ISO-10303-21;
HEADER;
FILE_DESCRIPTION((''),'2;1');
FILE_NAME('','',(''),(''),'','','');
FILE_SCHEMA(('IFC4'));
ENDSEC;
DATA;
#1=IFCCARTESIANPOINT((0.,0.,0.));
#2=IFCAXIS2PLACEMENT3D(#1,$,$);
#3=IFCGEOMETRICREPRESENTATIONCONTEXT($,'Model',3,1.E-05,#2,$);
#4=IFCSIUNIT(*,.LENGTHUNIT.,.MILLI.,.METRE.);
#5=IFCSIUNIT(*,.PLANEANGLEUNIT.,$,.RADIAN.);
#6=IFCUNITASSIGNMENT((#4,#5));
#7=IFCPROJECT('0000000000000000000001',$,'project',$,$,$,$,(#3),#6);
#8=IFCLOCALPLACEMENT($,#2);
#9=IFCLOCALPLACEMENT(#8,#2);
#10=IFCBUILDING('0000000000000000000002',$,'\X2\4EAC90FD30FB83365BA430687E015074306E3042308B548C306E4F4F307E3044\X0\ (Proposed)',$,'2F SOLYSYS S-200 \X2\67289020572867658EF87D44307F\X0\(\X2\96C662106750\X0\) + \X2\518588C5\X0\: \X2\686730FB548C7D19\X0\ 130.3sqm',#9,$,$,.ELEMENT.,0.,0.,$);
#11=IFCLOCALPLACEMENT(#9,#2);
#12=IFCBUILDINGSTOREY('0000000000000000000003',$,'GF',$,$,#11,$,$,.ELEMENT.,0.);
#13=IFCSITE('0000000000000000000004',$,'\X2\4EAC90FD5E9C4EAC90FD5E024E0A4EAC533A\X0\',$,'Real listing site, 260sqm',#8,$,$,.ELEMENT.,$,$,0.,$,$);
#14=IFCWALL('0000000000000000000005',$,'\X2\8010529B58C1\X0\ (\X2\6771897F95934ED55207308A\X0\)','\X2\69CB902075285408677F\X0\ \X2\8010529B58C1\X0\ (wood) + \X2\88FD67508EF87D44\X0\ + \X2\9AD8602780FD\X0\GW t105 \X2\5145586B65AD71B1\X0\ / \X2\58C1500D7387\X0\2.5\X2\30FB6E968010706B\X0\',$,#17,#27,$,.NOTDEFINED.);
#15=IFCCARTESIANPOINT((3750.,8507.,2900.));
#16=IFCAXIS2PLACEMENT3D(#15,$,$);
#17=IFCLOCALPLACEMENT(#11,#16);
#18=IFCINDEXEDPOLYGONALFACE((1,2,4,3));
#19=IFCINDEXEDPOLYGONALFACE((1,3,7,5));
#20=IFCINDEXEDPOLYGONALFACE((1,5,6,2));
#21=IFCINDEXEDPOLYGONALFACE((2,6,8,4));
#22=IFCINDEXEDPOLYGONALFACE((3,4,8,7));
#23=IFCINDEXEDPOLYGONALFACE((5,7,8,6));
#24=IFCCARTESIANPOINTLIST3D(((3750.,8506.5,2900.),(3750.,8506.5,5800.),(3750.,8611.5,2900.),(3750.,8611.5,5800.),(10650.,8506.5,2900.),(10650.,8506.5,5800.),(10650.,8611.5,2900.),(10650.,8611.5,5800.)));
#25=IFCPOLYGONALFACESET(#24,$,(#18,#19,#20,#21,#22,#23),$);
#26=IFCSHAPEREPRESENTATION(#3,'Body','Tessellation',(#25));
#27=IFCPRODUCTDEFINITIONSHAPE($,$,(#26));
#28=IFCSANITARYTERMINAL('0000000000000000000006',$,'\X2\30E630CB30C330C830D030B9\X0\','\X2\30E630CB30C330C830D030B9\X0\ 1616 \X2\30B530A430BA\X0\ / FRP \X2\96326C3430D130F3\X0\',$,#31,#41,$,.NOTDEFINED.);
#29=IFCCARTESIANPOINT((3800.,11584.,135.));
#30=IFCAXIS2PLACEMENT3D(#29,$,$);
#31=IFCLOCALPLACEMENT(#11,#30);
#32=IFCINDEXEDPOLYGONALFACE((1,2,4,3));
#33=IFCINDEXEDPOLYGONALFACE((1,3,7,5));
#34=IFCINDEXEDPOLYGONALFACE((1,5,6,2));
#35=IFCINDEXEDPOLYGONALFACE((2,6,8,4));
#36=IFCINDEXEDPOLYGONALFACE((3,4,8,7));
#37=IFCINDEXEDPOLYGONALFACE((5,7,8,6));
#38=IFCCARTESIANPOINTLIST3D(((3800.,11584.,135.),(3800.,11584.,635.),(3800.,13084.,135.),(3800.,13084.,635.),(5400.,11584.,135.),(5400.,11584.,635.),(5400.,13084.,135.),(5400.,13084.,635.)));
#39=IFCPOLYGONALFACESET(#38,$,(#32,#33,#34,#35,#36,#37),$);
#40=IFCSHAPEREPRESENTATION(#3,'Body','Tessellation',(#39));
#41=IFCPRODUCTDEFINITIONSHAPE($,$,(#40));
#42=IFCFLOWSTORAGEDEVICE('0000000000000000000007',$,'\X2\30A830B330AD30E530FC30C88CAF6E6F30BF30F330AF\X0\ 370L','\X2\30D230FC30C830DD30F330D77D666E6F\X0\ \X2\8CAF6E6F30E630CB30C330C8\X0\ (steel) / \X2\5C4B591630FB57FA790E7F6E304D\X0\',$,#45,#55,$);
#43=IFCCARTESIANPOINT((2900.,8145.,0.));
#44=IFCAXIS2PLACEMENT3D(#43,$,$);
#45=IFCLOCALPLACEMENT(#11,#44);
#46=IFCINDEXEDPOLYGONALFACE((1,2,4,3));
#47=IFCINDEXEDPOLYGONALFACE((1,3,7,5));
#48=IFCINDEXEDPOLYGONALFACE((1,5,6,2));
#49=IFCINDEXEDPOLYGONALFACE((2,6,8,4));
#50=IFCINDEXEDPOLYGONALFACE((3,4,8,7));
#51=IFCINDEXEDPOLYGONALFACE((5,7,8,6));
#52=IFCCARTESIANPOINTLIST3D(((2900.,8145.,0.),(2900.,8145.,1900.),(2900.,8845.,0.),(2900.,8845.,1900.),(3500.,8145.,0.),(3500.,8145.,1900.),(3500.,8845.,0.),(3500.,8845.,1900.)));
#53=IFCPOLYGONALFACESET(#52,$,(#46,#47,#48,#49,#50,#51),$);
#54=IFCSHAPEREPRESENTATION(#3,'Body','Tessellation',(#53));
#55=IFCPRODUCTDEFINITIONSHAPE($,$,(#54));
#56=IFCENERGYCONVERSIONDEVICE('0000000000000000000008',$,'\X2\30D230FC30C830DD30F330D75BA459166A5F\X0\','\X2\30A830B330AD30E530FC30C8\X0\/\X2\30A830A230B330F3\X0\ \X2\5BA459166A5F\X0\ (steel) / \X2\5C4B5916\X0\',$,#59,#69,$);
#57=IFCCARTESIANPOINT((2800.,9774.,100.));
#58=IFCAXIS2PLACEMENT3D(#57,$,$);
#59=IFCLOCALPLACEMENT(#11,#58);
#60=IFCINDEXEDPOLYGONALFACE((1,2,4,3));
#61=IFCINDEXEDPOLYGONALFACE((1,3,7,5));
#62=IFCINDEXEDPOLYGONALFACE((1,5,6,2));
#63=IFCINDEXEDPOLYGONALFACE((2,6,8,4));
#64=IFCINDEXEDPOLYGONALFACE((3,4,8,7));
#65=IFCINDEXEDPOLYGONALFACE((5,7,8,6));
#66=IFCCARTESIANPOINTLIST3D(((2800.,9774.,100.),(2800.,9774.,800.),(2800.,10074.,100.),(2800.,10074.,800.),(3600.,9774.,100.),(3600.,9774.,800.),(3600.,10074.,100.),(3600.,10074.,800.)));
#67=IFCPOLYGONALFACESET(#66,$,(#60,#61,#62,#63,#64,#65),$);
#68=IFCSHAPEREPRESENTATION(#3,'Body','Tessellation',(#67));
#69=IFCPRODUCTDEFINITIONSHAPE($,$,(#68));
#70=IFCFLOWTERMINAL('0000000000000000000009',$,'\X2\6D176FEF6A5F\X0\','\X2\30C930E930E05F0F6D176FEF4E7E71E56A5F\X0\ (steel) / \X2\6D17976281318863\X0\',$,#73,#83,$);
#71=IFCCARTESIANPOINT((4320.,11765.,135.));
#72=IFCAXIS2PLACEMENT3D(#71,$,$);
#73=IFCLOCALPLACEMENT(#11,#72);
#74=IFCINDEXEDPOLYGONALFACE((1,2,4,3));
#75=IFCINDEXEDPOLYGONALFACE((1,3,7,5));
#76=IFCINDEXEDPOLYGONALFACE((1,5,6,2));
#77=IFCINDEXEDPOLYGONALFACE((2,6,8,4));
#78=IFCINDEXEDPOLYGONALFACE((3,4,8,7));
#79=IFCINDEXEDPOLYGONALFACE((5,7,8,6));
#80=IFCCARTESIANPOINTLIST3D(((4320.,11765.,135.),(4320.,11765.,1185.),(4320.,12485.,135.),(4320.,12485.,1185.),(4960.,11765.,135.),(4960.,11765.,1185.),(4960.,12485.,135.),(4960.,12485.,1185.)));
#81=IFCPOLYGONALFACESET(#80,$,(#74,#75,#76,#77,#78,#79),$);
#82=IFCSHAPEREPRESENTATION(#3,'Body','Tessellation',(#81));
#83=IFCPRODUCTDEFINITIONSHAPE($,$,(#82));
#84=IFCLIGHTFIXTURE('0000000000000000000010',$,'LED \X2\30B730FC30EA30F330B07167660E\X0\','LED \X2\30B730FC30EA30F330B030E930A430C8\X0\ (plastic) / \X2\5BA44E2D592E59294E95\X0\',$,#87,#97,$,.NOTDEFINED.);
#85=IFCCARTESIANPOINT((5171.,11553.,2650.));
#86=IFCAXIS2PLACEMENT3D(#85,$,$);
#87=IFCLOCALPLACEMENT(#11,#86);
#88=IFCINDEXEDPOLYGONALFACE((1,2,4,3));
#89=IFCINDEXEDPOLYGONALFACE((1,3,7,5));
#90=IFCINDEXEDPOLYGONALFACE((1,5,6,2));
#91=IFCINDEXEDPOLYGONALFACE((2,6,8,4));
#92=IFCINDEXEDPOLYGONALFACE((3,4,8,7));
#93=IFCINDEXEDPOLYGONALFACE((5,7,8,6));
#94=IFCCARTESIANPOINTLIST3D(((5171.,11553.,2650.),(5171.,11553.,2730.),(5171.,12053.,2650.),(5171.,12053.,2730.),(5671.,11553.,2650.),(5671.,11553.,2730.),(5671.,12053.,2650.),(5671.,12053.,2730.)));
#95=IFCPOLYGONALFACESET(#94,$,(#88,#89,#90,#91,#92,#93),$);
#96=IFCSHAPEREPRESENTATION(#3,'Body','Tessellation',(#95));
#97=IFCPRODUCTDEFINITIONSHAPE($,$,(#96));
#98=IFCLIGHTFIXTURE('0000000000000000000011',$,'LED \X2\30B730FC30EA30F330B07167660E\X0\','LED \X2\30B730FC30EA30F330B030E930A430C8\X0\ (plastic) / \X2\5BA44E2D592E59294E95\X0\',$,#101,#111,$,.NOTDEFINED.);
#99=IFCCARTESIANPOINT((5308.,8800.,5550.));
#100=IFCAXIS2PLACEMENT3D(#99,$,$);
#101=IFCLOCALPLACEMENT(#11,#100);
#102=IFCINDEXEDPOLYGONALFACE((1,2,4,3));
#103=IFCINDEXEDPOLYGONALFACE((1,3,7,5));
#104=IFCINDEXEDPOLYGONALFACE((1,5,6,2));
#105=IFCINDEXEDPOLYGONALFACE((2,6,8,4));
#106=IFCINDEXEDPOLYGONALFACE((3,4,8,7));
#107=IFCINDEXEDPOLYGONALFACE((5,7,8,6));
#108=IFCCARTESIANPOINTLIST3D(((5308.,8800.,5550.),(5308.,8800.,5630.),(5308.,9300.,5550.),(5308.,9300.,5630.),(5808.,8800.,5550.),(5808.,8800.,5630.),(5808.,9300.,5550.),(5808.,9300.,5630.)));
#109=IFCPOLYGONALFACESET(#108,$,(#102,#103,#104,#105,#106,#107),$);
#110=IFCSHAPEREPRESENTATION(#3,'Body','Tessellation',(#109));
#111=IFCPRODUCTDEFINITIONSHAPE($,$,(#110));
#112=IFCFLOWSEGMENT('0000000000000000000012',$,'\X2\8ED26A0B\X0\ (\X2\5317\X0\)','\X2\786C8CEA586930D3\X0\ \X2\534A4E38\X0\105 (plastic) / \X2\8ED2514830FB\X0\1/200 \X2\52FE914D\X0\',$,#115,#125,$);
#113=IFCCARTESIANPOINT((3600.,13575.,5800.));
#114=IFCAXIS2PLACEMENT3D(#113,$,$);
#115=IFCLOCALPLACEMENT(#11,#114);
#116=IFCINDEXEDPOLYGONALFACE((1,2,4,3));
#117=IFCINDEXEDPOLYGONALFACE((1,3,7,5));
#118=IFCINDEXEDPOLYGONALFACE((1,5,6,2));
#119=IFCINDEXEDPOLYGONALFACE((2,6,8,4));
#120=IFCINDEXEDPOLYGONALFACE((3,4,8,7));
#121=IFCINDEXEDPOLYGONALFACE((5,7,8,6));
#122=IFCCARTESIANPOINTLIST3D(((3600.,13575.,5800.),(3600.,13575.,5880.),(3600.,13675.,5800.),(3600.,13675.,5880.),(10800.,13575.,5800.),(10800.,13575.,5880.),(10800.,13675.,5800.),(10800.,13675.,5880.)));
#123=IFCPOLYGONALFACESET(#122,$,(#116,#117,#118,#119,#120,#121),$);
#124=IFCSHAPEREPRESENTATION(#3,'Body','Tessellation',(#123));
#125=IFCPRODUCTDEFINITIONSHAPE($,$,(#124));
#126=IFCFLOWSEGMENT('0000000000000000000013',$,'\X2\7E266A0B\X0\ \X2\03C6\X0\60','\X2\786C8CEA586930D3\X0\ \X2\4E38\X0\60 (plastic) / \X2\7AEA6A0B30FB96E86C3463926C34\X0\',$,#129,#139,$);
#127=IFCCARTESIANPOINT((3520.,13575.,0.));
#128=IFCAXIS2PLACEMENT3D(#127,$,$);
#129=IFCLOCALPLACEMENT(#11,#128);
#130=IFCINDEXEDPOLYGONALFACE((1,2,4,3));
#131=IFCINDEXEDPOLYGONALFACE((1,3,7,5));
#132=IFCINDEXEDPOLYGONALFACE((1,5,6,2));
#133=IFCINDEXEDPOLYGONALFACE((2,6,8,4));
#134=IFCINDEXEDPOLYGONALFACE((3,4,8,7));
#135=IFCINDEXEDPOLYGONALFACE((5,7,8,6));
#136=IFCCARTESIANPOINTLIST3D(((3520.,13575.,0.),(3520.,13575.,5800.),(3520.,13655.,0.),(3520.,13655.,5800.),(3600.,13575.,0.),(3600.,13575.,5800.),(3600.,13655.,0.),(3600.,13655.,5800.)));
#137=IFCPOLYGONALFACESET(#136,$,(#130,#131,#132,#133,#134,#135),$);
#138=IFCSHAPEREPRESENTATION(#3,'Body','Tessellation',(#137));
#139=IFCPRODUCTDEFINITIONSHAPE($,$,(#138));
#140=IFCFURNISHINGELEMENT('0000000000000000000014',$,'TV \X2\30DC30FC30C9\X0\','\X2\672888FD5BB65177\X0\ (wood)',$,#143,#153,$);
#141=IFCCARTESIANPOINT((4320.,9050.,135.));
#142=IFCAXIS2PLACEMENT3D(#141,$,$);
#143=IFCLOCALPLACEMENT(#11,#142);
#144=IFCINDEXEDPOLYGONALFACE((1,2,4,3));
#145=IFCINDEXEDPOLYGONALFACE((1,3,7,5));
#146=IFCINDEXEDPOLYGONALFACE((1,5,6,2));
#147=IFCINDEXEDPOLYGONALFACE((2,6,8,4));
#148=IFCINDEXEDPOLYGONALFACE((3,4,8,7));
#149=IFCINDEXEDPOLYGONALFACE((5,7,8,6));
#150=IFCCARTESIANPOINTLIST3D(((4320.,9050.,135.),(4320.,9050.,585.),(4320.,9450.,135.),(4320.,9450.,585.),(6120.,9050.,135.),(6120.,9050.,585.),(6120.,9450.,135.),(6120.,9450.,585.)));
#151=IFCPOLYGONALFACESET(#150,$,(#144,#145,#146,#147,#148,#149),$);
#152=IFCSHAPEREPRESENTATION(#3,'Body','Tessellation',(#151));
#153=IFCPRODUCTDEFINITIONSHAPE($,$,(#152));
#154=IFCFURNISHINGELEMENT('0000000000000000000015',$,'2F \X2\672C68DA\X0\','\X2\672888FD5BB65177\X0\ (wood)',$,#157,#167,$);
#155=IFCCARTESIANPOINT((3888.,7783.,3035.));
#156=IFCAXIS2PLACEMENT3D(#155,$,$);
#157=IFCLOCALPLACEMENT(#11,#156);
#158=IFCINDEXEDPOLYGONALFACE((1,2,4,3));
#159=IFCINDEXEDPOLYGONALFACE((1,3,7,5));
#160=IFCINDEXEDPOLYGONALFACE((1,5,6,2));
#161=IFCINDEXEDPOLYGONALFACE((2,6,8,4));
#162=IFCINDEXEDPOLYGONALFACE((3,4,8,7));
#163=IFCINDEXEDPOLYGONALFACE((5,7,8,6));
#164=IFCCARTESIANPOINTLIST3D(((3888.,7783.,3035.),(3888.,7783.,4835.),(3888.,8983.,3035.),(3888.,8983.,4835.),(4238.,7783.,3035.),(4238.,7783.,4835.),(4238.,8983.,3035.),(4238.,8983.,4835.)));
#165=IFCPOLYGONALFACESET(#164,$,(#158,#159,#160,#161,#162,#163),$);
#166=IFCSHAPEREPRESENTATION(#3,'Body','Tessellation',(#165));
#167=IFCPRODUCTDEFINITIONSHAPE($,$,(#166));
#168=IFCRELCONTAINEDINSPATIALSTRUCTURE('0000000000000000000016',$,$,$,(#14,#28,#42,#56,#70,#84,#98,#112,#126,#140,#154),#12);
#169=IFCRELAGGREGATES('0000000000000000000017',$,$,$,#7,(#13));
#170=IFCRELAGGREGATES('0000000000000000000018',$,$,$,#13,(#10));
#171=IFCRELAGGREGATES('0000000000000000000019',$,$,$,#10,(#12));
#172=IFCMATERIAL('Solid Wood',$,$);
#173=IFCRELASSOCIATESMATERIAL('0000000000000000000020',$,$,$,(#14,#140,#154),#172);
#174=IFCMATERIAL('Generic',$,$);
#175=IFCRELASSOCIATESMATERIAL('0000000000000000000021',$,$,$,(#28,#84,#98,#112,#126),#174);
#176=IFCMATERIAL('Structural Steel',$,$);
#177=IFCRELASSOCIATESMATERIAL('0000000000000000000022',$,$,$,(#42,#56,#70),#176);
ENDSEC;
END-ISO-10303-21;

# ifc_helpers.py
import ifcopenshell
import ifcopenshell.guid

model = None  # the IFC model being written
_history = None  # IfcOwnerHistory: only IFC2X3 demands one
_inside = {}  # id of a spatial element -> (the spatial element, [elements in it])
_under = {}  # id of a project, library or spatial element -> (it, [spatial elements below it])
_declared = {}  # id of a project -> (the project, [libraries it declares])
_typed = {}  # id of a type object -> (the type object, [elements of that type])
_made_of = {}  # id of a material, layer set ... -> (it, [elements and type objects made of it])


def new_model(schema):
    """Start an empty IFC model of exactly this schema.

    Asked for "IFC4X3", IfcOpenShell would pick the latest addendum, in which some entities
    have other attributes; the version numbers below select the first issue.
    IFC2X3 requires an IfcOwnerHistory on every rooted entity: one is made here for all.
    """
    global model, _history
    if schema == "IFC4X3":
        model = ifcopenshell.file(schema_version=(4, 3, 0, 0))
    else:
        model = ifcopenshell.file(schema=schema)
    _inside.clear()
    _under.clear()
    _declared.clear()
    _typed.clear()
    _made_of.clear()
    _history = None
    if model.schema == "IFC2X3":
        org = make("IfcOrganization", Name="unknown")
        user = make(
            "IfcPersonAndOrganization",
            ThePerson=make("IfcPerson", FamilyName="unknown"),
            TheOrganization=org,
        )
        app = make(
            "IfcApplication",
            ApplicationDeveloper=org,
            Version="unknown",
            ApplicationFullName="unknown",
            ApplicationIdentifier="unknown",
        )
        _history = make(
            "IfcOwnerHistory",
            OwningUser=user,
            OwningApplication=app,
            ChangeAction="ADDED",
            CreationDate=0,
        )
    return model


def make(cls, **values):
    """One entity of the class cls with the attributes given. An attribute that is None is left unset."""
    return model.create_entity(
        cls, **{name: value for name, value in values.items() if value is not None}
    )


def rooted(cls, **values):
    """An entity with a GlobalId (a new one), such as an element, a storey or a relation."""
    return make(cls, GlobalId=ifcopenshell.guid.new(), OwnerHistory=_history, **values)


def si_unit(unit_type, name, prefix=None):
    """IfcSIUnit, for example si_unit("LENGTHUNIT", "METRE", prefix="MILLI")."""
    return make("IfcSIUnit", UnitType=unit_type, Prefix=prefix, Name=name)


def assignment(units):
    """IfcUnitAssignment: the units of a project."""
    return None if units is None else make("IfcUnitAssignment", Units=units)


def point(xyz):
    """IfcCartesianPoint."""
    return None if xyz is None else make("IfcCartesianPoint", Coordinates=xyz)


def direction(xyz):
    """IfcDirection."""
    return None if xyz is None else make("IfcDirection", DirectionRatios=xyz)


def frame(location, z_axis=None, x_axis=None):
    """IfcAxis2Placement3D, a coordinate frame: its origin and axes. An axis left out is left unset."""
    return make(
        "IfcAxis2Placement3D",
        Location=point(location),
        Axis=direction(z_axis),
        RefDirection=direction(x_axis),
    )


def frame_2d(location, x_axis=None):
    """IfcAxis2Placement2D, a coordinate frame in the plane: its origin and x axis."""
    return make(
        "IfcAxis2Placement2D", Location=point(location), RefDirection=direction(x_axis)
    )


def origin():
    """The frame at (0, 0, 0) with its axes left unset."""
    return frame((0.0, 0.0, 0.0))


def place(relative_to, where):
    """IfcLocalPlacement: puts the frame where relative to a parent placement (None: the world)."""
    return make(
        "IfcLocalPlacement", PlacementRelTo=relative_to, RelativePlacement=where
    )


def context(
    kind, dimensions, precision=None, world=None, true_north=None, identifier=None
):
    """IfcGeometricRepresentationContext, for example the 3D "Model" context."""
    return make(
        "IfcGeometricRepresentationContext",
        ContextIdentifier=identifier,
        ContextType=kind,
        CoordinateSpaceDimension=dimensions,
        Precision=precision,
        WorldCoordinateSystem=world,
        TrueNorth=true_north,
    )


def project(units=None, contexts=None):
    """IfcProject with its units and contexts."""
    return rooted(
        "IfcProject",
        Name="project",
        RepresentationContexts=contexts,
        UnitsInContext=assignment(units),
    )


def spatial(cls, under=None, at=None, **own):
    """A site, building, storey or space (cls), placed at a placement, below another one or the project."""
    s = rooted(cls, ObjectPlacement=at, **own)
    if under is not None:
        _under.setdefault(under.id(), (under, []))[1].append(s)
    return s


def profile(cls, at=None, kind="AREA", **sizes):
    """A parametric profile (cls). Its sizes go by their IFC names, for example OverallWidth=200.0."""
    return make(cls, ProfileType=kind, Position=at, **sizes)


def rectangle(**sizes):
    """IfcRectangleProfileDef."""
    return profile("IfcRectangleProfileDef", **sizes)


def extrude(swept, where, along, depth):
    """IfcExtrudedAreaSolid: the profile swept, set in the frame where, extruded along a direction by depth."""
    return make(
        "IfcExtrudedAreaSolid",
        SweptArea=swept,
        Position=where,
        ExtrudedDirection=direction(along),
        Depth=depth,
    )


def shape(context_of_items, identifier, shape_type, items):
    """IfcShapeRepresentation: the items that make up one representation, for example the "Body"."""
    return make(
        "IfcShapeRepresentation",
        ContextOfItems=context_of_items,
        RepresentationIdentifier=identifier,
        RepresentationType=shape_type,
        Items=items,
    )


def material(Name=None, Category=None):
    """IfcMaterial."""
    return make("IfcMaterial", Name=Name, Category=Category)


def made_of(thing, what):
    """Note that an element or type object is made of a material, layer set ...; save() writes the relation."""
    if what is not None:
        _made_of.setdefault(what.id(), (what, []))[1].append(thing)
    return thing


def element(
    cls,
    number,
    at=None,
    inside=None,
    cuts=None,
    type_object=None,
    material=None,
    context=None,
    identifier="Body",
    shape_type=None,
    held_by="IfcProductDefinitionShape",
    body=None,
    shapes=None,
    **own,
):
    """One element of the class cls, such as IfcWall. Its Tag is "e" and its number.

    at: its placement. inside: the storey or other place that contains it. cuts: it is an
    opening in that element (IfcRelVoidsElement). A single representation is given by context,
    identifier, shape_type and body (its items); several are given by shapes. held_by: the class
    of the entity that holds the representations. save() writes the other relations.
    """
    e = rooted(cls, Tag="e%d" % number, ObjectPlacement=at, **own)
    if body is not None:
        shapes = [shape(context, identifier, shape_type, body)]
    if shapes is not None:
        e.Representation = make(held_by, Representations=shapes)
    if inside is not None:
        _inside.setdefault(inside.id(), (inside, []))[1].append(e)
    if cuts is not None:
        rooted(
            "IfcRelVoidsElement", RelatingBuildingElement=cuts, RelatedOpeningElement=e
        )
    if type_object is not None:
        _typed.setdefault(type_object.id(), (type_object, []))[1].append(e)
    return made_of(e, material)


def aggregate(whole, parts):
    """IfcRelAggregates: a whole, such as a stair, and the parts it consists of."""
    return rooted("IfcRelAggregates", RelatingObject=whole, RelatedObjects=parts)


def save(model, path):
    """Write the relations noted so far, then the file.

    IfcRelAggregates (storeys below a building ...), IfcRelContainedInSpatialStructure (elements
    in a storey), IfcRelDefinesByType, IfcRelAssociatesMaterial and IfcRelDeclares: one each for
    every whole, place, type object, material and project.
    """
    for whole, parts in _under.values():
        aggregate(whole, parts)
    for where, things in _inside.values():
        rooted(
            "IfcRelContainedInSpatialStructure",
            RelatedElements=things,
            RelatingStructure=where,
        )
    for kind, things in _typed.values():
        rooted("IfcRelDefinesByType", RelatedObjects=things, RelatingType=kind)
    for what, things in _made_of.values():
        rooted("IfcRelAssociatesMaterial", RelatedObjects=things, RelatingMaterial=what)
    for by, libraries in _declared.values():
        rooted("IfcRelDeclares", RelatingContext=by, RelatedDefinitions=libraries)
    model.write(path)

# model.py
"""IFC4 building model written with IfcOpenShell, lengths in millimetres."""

from ifc_helpers import new_model, si_unit, frame, frame_2d, origin, place, context, project, spatial, rectangle, extrude, material, element, save


model = new_model("IFC4")

# Units and contexts
model_context = context("Model", 3, precision=1e-05, world=origin())
ifc_project = project(units=[si_unit("LENGTHUNIT", "METRE", prefix="MILLI"), si_unit("PLANEANGLEUNIT", "RADIAN")], contexts=[model_context])

# Site, building, storey
site_placement = place(None, origin())
site = spatial("IfcSite", under=ifc_project, at=site_placement, Name="京都府京都市上京区", ObjectType="Real listing site, 260sqm", CompositionType="ELEMENT", RefElevation=0.0)
building_placement = place(site_placement, origin())
building = spatial("IfcBuilding", under=site, at=building_placement, Name="京都・茶室と縁側のある和の住まい (Proposed)", ObjectType="2F SOLYSYS S-200 木造在来軸組み(集成材) + 内装: 桧・和紙 130.3sqm", CompositionType="ELEMENT", ElevationOfRefHeight=0.0, ElevationOfTerrain=0.0)
storey_placement = place(building_placement, origin())
storey = spatial("IfcBuildingStorey", under=building, at=storey_placement, Name="GF", CompositionType="ELEMENT", Elevation=0.0)

# Shared definitions
ifc_material_1 = material(Name="Solid Wood")

# Wall
wall_1_placement = place(storey_placement, frame((3750.0, 8507.0, 2900.0)))
element("IfcWall", 1, at=wall_1_placement, inside=storey, material=ifc_material_1, Name="耐力壁 (東西間仕切り)", Description="構造用合板 耐力壁 (wood) + 製材軸組 + 高性能GW t105 充填断熱 / 壁倍率2.5・準耐火", PredefinedType="NOTDEFINED", context=model_context, shape_type="SweptSolid", body=[
    extrude(rectangle(XDim=6900.0, YDim=105.0, at=frame_2d((3450.0, 52.0))), frame((3750.0, 8507.0, 2900.0)), (0.0, 0.0, 1.0), 2900.0),
])

# Sanitary terminal
ifc_material_2 = material(Name="Generic")
sanitary_terminal_placement = place(storey_placement, frame((3800.0, 11584.0, 135.0)))
element("IfcSanitaryTerminal", 2, at=sanitary_terminal_placement, inside=storey, material=ifc_material_2, Name="ユニットバス", Description="ユニットバス 1616 サイズ / FRP 防水パン", PredefinedType="NOTDEFINED", context=model_context, shape_type="SweptSolid", body=[
    extrude(rectangle(XDim=1600.0, YDim=1500.0, at=frame_2d((800.0, 750.0))), frame((3800.0, 11584.0, 135.0)), (0.0, 0.0, 1.0), 500.0),
])

# Flow storage device
ifc_material_3 = material(Name="Structural Steel")
flow_storage_device_placement = place(storey_placement, frame((2900.0, 8145.0, 0.0)))
element("IfcFlowStorageDevice", 3, at=flow_storage_device_placement, inside=storey, material=ifc_material_3, Name="エコキュート貯湯タンク 370L", Description="ヒートポンプ給湯 貯湯ユニット (steel) / 屋外・基礎置き", context=model_context, shape_type="SweptSolid", body=[
    extrude(rectangle(XDim=600.0, YDim=700.0, at=frame_2d((300.0, 350.0))), frame((2900.0, 8145.0, 0.0)), (0.0, 0.0, 1.0), 1900.0),
])

# Energy conversion device
energy_conversion_device_placement = place(storey_placement, frame((2800.0, 9774.0, 100.0)))
element("IfcEnergyConversionDevice", 4, at=energy_conversion_device_placement, inside=storey, material=ifc_material_3, Name="ヒートポンプ室外機", Description="エコキュート/エアコン 室外機 (steel) / 屋外", context=model_context, shape_type="SweptSolid", body=[
    extrude(rectangle(XDim=800.0, YDim=300.0, at=frame_2d((400.0, 150.0))), frame((2800.0, 9774.0, 100.0)), (0.0, 0.0, 1.0), 700.0),
])

# Flow terminal
flow_terminal_placement = place(storey_placement, frame((4320.0, 11765.0, 135.0)))
element("IfcFlowTerminal", 5, at=flow_terminal_placement, inside=storey, material=ifc_material_3, Name="洗濯機", Description="ドラム式洗濯乾燥機 (steel) / 洗面脱衣", context=model_context, shape_type="SweptSolid", body=[
    extrude(rectangle(XDim=640.0, YDim=720.0, at=frame_2d((320.0, 360.0))), frame((4320.0, 11765.0, 135.0)), (0.0, 0.0, 1.0), 1050.0),
])

# Light fixtures
light_fixture_1_placement = place(storey_placement, frame((5171.0, 11553.0, 2650.0)))
element("IfcLightFixture", 6, at=light_fixture_1_placement, inside=storey, material=ifc_material_2, Name="LED シーリング照明", Description="LED シーリングライト (plastic) / 室中央天井", PredefinedType="NOTDEFINED", context=model_context, shape_type="SweptSolid", body=[
    extrude(rectangle(XDim=500.0, YDim=500.0, at=frame_2d((250.0, 250.0))), frame((5171.0, 11553.0, 2650.0)), (0.0, 0.0, 1.0), 80.0),
])
light_fixture_2_placement = place(storey_placement, frame((5308.0, 8800.0, 5550.0)))
element("IfcLightFixture", 7, at=light_fixture_2_placement, inside=storey, material=ifc_material_2, Name="LED シーリング照明", Description="LED シーリングライト (plastic) / 室中央天井", PredefinedType="NOTDEFINED", context=model_context, shape_type="SweptSolid", body=[
    extrude(rectangle(XDim=500.0, YDim=500.0, at=frame_2d((250.0, 250.0))), frame((5308.0, 8800.0, 5550.0)), (0.0, 0.0, 1.0), 80.0),
])

# Flow segments
flow_segment_1_placement = place(storey_placement, frame((3600.0, 13575.0, 5800.0)))
element("IfcFlowSegment", 8, at=flow_segment_1_placement, inside=storey, material=ifc_material_2, Name="軒樋 (北)", Description="硬質塩ビ 半丸105 (plastic) / 軒先・1/200 勾配", context=model_context, shape_type="SweptSolid", body=[
    extrude(rectangle(XDim=7200.0, YDim=100.0, at=frame_2d((3600.0, 50.0))), frame((3600.0, 13575.0, 5800.0)), (0.0, 0.0, 1.0), 80.0),
])
flow_segment_2_placement = place(storey_placement, frame((3520.0, 13575.0, 0.0)))
element("IfcFlowSegment", 9, at=flow_segment_2_placement, inside=storey, material=ifc_material_2, Name="縦樋 φ60", Description="硬質塩ビ 丸60 (plastic) / 竪樋・雨水排水", context=model_context, shape_type="SweptSolid", body=[
    extrude(rectangle(XDim=80.0, YDim=80.0, at=frame_2d((40.0, 40.0))), frame((3520.0, 13575.0, 0.0)), (0.0, 0.0, 1.0), 5800.0),
])

# Furnishing elements
furnishing_1_placement = place(storey_placement, frame((4320.0, 9050.0, 135.0)))
element("IfcFurnishingElement", 10, at=furnishing_1_placement, inside=storey, material=ifc_material_1, Name="TV ボード", Description="木製家具 (wood)", context=model_context, shape_type="SweptSolid", body=[
    extrude(rectangle(XDim=1800.0, YDim=400.0, at=frame_2d((900.0, 200.0))), frame((4320.0, 9050.0, 135.0)), (0.0, 0.0, 1.0), 450.0),
])
furnishing_2_placement = place(storey_placement, frame((3888.0, 7783.0, 3035.0)))
element("IfcFurnishingElement", 11, at=furnishing_2_placement, inside=storey, material=ifc_material_1, Name="2F 本棚", Description="木製家具 (wood)", context=model_context, shape_type="SweptSolid", body=[
    extrude(rectangle(XDim=350.0, YDim=1200.0, at=frame_2d((175.0, 600.0))), frame((3888.0, 7783.0, 3035.0)), (0.0, 0.0, 1.0), 1800.0),
])

save(model, "model.ifc")
